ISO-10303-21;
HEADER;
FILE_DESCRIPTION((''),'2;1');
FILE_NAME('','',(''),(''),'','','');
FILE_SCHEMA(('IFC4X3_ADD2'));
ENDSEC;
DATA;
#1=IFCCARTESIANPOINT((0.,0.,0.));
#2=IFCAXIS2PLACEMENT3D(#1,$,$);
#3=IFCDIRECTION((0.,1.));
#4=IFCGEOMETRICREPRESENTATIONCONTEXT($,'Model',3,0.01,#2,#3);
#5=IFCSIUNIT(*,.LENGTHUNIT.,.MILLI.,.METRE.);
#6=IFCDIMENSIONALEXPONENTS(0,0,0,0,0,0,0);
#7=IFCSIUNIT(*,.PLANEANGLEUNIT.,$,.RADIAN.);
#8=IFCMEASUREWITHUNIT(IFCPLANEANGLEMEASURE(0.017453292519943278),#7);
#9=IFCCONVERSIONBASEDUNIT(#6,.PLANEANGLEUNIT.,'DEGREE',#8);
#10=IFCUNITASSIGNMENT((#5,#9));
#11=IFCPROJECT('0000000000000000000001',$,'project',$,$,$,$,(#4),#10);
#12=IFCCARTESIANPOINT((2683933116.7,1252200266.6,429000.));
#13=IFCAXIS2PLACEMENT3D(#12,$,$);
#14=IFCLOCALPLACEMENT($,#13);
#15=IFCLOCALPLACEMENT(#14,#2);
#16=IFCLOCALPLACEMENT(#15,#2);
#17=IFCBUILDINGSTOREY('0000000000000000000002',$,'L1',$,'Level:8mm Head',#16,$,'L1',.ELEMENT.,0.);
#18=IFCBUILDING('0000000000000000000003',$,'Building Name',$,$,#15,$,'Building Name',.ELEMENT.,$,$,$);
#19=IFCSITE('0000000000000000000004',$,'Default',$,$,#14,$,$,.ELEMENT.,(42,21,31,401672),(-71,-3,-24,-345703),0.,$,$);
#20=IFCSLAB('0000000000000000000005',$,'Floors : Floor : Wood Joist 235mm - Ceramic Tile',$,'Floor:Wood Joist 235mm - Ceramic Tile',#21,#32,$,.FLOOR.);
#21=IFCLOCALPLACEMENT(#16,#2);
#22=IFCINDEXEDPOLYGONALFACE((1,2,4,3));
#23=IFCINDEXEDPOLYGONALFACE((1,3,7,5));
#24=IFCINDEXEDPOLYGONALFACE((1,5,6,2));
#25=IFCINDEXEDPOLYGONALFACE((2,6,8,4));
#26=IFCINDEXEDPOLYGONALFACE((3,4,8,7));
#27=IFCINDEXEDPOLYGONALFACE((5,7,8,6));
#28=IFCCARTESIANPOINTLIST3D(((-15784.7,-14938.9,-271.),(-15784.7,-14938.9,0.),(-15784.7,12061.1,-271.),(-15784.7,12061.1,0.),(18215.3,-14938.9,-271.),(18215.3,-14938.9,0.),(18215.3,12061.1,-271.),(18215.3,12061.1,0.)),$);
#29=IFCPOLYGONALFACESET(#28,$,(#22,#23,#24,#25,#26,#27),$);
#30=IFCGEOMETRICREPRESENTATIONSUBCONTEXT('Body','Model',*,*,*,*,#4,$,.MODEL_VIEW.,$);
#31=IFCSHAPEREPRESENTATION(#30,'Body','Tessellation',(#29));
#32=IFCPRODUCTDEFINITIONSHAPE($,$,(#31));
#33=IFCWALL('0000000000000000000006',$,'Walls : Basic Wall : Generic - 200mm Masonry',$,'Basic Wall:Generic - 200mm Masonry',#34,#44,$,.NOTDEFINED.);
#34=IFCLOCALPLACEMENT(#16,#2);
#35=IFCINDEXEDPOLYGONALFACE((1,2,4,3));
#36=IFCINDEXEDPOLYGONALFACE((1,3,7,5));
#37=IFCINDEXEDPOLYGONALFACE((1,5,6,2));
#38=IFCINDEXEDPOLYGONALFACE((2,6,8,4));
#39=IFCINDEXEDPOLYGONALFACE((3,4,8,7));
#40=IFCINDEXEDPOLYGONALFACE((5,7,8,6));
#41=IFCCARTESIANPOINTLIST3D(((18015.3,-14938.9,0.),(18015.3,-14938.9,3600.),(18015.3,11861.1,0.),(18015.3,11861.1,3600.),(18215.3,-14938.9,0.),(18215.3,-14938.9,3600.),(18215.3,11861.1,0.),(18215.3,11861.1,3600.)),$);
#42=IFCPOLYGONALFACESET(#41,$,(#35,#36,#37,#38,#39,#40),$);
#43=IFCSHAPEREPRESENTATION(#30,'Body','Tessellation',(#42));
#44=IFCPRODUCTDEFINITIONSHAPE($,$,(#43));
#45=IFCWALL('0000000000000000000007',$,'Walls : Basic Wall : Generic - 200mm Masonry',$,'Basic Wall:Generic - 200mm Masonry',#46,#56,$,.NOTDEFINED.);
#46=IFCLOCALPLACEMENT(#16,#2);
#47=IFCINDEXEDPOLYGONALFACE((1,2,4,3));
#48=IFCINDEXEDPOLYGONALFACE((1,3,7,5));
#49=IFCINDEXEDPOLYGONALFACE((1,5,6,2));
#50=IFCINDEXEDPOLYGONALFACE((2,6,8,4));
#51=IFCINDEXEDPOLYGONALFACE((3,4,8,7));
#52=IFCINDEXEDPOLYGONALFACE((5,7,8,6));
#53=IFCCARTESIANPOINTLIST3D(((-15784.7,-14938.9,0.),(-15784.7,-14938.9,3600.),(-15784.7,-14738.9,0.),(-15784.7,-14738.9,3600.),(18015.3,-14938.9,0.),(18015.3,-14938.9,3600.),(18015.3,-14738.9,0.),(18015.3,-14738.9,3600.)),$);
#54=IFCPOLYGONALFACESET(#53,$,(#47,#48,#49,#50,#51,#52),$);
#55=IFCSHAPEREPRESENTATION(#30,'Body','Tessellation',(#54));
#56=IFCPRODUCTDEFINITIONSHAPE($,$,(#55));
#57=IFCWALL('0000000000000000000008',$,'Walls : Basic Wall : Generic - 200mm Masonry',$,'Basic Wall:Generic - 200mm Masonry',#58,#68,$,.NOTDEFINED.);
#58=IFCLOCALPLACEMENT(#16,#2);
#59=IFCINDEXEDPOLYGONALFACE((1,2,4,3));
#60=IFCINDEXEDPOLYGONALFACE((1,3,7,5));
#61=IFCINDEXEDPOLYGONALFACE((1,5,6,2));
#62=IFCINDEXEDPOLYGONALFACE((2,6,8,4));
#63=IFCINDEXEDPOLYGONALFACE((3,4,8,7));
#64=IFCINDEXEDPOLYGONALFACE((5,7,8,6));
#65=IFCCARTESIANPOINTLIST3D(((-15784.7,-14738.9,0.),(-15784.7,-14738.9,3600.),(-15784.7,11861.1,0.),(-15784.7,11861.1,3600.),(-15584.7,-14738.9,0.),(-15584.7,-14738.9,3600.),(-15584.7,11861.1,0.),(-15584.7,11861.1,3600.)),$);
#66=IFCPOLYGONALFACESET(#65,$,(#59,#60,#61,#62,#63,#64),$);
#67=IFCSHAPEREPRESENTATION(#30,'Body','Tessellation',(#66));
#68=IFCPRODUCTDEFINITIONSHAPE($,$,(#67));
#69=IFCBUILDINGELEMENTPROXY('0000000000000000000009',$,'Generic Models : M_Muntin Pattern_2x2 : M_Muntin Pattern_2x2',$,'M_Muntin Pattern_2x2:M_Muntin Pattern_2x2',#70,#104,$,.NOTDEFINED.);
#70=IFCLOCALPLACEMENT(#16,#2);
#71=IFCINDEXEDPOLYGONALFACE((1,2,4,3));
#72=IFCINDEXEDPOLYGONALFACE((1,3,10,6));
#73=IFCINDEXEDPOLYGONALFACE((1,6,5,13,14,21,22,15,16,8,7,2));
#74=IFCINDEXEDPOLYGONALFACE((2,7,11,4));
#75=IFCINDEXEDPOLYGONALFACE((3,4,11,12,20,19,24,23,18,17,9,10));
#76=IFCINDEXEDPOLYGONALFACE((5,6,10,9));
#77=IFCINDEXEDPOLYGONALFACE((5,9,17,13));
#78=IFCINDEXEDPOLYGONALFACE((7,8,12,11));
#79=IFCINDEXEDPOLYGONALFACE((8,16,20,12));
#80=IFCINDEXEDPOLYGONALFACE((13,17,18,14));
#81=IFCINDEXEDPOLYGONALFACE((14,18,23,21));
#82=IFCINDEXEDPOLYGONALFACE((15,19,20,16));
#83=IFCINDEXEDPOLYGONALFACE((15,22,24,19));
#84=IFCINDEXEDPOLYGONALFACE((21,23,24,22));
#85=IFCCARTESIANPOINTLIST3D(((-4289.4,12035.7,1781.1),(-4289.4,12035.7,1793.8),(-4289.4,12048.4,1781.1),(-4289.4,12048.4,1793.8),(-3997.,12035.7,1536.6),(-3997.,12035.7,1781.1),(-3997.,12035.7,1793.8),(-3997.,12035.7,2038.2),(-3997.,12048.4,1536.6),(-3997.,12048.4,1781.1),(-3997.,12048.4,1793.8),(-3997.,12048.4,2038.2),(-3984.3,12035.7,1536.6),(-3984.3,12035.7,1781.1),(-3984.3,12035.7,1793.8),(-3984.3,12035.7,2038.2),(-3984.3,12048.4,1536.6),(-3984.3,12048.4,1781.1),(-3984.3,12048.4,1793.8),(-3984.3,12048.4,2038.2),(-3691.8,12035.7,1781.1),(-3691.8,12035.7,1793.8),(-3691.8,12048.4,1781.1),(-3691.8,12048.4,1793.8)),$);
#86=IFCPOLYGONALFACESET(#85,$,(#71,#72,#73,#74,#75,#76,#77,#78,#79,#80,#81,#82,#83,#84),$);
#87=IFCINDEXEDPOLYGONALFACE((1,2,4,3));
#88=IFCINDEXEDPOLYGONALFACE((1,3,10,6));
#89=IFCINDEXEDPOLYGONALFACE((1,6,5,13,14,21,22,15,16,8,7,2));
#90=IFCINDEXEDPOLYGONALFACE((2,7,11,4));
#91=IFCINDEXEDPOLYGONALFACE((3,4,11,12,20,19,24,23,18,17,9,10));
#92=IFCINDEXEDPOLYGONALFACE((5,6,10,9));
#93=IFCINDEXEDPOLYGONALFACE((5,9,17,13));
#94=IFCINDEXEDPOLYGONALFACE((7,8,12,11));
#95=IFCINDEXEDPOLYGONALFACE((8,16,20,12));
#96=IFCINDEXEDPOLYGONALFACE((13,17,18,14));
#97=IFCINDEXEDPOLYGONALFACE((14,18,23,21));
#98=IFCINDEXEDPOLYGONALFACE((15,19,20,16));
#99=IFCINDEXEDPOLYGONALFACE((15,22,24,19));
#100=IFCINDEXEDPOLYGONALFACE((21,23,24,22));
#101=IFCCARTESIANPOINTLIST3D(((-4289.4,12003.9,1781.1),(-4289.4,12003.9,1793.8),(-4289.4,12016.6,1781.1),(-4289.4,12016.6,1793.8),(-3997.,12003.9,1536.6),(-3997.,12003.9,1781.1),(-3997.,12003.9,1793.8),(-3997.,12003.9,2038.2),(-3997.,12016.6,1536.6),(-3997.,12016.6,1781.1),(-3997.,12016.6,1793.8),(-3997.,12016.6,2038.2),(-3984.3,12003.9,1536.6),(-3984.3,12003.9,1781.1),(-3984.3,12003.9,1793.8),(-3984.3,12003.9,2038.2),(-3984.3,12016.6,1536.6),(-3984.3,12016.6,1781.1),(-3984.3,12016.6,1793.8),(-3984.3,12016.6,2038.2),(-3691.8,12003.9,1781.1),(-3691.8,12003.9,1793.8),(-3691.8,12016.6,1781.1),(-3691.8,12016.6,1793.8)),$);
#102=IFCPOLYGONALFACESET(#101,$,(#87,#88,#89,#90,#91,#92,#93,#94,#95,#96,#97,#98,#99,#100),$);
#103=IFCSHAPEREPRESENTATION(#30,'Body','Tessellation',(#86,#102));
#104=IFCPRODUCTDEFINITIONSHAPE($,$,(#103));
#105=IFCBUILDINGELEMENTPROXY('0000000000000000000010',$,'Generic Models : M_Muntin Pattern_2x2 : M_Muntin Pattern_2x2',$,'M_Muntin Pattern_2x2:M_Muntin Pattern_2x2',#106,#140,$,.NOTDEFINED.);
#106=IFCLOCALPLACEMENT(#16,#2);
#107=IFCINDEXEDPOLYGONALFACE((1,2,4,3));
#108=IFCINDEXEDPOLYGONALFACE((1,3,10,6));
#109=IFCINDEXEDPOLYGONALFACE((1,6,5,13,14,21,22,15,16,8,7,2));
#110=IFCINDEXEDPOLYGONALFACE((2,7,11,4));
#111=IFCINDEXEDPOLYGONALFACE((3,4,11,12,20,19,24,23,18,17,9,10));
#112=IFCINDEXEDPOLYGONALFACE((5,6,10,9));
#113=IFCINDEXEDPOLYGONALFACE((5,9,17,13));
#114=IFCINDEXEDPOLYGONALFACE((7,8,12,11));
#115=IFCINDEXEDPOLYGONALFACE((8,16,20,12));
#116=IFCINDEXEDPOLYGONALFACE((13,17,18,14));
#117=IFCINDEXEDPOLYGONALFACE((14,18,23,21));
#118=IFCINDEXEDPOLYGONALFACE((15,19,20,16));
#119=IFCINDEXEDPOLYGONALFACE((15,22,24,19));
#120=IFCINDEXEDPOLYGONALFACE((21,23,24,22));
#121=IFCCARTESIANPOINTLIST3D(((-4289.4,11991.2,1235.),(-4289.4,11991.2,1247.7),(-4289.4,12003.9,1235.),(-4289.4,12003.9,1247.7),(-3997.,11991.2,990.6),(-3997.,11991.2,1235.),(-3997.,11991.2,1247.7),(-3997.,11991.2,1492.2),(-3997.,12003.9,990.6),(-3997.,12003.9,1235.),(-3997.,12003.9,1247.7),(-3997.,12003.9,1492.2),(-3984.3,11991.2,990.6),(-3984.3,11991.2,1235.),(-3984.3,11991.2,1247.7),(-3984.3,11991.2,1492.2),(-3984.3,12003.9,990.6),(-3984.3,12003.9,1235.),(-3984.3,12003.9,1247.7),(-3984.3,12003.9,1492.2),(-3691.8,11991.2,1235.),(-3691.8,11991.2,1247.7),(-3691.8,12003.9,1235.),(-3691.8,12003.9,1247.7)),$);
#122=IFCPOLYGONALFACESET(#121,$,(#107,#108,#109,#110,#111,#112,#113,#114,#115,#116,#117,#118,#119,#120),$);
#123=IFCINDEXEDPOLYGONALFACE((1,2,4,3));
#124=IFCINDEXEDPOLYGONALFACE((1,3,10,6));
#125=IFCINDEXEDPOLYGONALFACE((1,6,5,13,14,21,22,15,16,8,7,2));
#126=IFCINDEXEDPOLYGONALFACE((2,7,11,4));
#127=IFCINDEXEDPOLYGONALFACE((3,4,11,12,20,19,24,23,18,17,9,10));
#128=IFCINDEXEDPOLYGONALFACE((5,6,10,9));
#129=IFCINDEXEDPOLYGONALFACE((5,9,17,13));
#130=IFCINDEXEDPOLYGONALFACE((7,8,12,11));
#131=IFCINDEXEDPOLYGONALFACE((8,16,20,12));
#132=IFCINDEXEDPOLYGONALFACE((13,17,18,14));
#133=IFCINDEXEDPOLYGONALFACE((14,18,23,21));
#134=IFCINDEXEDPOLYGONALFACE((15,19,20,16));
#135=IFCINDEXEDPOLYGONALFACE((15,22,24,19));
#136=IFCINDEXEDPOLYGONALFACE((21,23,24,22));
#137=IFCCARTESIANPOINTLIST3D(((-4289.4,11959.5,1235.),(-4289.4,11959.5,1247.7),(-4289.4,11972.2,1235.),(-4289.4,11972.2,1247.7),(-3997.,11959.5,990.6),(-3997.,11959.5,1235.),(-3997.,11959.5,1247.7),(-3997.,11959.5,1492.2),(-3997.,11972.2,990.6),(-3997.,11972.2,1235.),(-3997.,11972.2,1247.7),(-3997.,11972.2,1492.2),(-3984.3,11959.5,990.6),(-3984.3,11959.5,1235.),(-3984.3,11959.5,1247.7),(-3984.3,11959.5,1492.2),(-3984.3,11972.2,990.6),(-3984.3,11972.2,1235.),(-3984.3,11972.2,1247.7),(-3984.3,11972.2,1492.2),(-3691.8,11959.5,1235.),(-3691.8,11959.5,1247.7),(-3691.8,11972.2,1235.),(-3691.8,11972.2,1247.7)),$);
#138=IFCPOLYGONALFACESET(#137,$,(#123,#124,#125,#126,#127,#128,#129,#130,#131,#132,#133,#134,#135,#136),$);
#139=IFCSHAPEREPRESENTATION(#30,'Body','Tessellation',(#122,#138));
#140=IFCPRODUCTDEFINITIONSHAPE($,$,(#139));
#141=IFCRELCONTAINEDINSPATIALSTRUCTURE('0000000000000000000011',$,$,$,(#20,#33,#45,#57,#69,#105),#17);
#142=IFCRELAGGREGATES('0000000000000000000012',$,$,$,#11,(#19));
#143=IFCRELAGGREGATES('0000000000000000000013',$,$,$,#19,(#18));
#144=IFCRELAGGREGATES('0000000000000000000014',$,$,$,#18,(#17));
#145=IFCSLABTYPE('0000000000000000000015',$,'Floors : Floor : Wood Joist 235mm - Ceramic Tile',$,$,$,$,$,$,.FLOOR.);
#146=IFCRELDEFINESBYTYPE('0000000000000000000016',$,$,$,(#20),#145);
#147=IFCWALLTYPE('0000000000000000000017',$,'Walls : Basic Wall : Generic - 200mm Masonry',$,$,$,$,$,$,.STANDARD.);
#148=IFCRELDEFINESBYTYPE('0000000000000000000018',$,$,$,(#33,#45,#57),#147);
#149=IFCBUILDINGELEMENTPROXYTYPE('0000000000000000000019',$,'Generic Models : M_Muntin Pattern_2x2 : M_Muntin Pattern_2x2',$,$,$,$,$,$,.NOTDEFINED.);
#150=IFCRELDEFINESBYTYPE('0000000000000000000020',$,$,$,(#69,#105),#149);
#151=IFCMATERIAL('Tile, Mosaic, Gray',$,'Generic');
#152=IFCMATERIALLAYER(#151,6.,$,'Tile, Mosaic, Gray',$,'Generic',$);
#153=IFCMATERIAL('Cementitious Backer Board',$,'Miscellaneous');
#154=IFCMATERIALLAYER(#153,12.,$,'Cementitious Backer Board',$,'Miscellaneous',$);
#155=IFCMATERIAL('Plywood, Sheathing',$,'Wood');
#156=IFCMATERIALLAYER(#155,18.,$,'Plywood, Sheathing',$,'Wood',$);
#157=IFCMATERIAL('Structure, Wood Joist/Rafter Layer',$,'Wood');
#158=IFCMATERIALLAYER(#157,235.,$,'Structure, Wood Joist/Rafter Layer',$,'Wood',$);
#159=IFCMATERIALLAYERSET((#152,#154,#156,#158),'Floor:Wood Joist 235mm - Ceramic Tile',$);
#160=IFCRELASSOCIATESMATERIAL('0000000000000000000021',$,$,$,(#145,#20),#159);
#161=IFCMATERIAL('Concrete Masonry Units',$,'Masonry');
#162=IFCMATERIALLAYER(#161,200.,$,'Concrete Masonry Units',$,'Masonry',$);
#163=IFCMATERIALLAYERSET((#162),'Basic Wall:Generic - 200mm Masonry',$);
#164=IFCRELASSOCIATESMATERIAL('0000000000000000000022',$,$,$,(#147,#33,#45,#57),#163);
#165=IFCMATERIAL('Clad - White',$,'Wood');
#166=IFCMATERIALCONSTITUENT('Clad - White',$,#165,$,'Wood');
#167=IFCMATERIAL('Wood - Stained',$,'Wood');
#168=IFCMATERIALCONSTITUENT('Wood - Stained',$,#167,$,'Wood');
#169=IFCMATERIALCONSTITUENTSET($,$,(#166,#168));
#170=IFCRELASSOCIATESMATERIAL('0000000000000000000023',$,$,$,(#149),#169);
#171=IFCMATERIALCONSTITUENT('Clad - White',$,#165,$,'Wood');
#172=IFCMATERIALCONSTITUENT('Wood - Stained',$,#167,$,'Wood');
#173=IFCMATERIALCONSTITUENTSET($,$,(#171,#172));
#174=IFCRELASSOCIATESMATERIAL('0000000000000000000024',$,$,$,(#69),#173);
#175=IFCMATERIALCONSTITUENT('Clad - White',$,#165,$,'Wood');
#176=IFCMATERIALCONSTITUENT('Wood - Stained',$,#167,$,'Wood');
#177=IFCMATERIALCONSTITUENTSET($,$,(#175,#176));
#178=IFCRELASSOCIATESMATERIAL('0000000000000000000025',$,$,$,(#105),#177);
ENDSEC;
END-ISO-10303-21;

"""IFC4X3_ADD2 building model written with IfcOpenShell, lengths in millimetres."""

from ifc_helpers import new_model, entity, si_unit, converted_unit, direction, frame, frame_2d, origin, origin_2d_with_axis, place, context, subcontext, project, spatial, polyline, rectangle, outline, extrude, source, transform, mapped, material, layer, layer_set, layer_usage, constituent, constituent_set, type_object, type_shapes, element, save


model = new_model("IFC4X3_ADD2")

# Units and contexts
model_context = context("Model", 3, precision=0.01, world=origin(), true_north=direction((0.0, 1.0)))
body_context = subcontext(model_context, "Body", "Model", "MODEL_VIEW")
ifc_project = project(units=[si_unit("LENGTHUNIT", "METRE", prefix="MILLI"), converted_unit("PLANEANGLEUNIT", "DEGREE", entity("IfcPlaneAngleMeasure", 0.017453292519943278), si_unit("PLANEANGLEUNIT", "RADIAN"), dimensions=[0, 0, 0, 0, 0, 0, 0])], contexts=[model_context])

# Site, building, storey
site_placement = place(None, frame((2683933116.7, 1252200266.6, 429000.0)))
site = spatial("IfcSite", under=ifc_project, at=site_placement, Name="Default", CompositionType="ELEMENT", RefLatitude=(42, 21, 31, 401672), RefLongitude=(-71, -3, -24, -345703), RefElevation=0.0)
building_placement = place(site_placement, origin())
building = spatial("IfcBuilding", under=site, at=building_placement, Name="Building Name", LongName="Building Name", CompositionType="ELEMENT")
storey_placement = place(building_placement, origin())
storey = spatial("IfcBuildingStorey", under=building, at=storey_placement, Name="L1", ObjectType="Level:8mm Head", LongName="L1", CompositionType="ELEMENT", Elevation=0.0)

# Slab
ifc_material_1 = material(Name="Tile, Mosaic, Gray", Category="Generic")
ifc_layer_1 = layer(ifc_material_1, 6.0, Name="Tile, Mosaic, Gray", Category="Generic")
ifc_material_2 = material(Name="Cementitious Backer Board", Category="Miscellaneous")
ifc_layer_2 = layer(ifc_material_2, 12.0, Name="Cementitious Backer Board", Category="Miscellaneous")
ifc_material_3 = material(Name="Plywood, Sheathing", Category="Wood")
ifc_layer_3 = layer(ifc_material_3, 18.0, Name="Plywood, Sheathing", Category="Wood")
ifc_material_4 = material(Name="Structure, Wood Joist/Rafter Layer", Category="Wood")
ifc_layer_4 = layer(ifc_material_4, 235.0, Name="Structure, Wood Joist/Rafter Layer", Category="Wood")
ifc_layer_set_1 = layer_set([ifc_layer_1, ifc_layer_2, ifc_layer_3, ifc_layer_4], Name="Floor:Wood Joist 235mm - Ceramic Tile")
ifc_layer_usage = layer_usage(ifc_layer_set_1, "AXIS3", "POSITIVE", 0.0)
slab_type = type_object("IfcSlabType", Name="Floors : Floor : Wood Joist 235mm - Ceramic Tile", PredefinedType="FLOOR", material=ifc_layer_set_1)
slab_placement = place(storey_placement, origin())
element("IfcSlab", 1, at=slab_placement, inside=storey, type_object=slab_type, material=ifc_layer_usage, Name="Floors : Floor : Wood Joist 235mm - Ceramic Tile", ObjectType="Floor:Wood Joist 235mm - Ceramic Tile", PredefinedType="FLOOR", context=body_context, shape_type="SweptSolid", body=[
    extrude(rectangle(XDim=27000.0, YDim=34000.0, at=origin_2d_with_axis()), frame((1215.3, -1438.9, 0.0), z_axis=(0.0, 0.0, -1.0), x_axis=(0.0, 1.0, 0.0)), (0.0, 0.0, 1.0), 271.0),
])

# Shared definitions
ifc_material_5 = material(Name="Concrete Masonry Units", Category="Masonry")
ifc_layer_5 = layer(ifc_material_5, 200.0, Name="Concrete Masonry Units", Category="Masonry")
ifc_layer_set_2 = layer_set([ifc_layer_5], Name="Basic Wall:Generic - 200mm Masonry")
wall_type = type_object("IfcWallType", Name="Walls : Basic Wall : Generic - 200mm Masonry", PredefinedType="STANDARD", material=ifc_layer_set_2)
ifc_material_6 = material(Name="Wood - Stained", Category="Wood")

# Walls
wall_1_placement = place(storey_placement, frame((18115.3, 11861.1, 0.0), z_axis=(0.0, 0.0, 1.0), x_axis=(0.0, -1.0, 0.0)))
element("IfcWall", 2, at=wall_1_placement, inside=storey, type_object=wall_type, material=ifc_layer_set_2, Name="Walls : Basic Wall : Generic - 200mm Masonry", ObjectType="Basic Wall:Generic - 200mm Masonry", PredefinedType="NOTDEFINED", context=body_context, shape_type="SweptSolid", body=[
    extrude(rectangle(XDim=26800.0, YDim=200.0, at=frame_2d((13400.0, 0.0), x_axis=(-1.0, 0.0))), origin(), (0.0, 0.0, 1.0), 3600.0),
])
wall_2_placement = place(storey_placement, frame((18015.3, -14838.9, 0.0), z_axis=(0.0, 0.0, 1.0), x_axis=(-1.0, 0.0, 0.0)))
element("IfcWall", 3, at=wall_2_placement, inside=storey, type_object=wall_type, material=ifc_layer_set_2, Name="Walls : Basic Wall : Generic - 200mm Masonry", ObjectType="Basic Wall:Generic - 200mm Masonry", PredefinedType="NOTDEFINED", context=body_context, shape_type="SweptSolid", body=[
    extrude(rectangle(XDim=33800.0, YDim=200.0, at=frame_2d((16900.0, 0.0), x_axis=(-1.0, 0.0))), origin(), (0.0, 0.0, 1.0), 3600.0),
])
wall_3_placement = place(storey_placement, frame((-15684.7, -14738.9, 0.0), z_axis=(0.0, 0.0, 1.0), x_axis=(0.0, 1.0, 0.0)))
element("IfcWall", 4, at=wall_3_placement, inside=storey, type_object=wall_type, material=ifc_layer_set_2, Name="Walls : Basic Wall : Generic - 200mm Masonry", ObjectType="Basic Wall:Generic - 200mm Masonry", PredefinedType="NOTDEFINED", context=body_context, shape_type="SweptSolid", body=[
    extrude(rectangle(XDim=26600.0, YDim=200.0, at=frame_2d((13300.0, 0.0), x_axis=(-1.0, 0.0))), origin(), (0.0, 0.0, 1.0), 3600.0),
])

# Building element proxies
ifc_material_7 = material(Name="Clad - White", Category="Wood")
ifc_constituent_1 = constituent(ifc_material_7, Name="Clad - White", Category="Wood")
ifc_constituent_2 = constituent(ifc_material_6, Name="Wood - Stained", Category="Wood")
ifc_constituent_set_1 = constituent_set(constituents=[ifc_constituent_1, ifc_constituent_2])
ifc_constituent_3 = constituent(ifc_material_7, Name="Clad - White", Category="Wood")
ifc_constituent_4 = constituent(ifc_material_6, Name="Wood - Stained", Category="Wood")
ifc_constituent_set_2 = constituent_set(constituents=[ifc_constituent_3, ifc_constituent_4])
building_element_proxy_type_1 = type_object("IfcBuildingElementProxyType", Name="Generic Models : M_Muntin Pattern_2x2 : M_Muntin Pattern_2x2", PredefinedType="NOTDEFINED", material=ifc_constituent_set_2)
shared_shape_1 = source(origin(), body_context, "Body", "SweptSolid", [
    extrude(outline(polyline([(6.4, -6.4), (250.8, -6.4), (250.8, 6.3), (6.4, 6.3), (6.4, 298.8), (-6.3, 298.8), (-6.3, 6.3), (-250.8, 6.3), (-250.8, -6.4), (-6.3, -6.4), (-6.3, -298.8), (6.4, -298.8), (6.4, -6.4)])), frame((0.0, 9.5, 250.8), z_axis=(0.0, 1.0, 0.0), x_axis=(0.0, 0.0, 1.0)), (0.0, 0.0, 1.0), 12.7),
    extrude(outline(polyline([(6.4, -6.4), (250.8, -6.4), (250.8, 6.3), (6.4, 6.3), (6.4, 298.8), (-6.3, 298.8), (-6.3, 6.3), (-250.8, 6.3), (-250.8, -6.4), (-6.3, -6.4), (-6.3, -298.8), (6.4, -298.8), (6.4, -6.4)])), frame((0.0, -22.2, 250.8), z_axis=(0.0, 1.0, 0.0), x_axis=(0.0, 0.0, 1.0)), (0.0, 0.0, 1.0), 12.7),
])
type_shapes(building_element_proxy_type_1, [shared_shape_1])
proxy_1_placement = place(storey_placement, frame((-3990.6, 12026.1, 1536.6)))
element("IfcBuildingElementProxy", 5, at=proxy_1_placement, inside=storey, type_object=building_element_proxy_type_1, material=ifc_constituent_set_1, Name="Generic Models : M_Muntin Pattern_2x2 : M_Muntin Pattern_2x2", ObjectType="M_Muntin Pattern_2x2:M_Muntin Pattern_2x2", PredefinedType="NOTDEFINED", context=body_context, shape_type="MappedRepresentation", body=[
    mapped(shared_shape_1, transform((0.0, 0.0, 0.0), scale=1.0)),
])
ifc_constituent_5 = constituent(ifc_material_7, Name="Clad - White", Category="Wood")
ifc_constituent_6 = constituent(ifc_material_6, Name="Wood - Stained", Category="Wood")
ifc_constituent_set_3 = constituent_set(constituents=[ifc_constituent_5, ifc_constituent_6])
proxy_2_placement = place(storey_placement, frame((-3990.6, 11981.7, 990.6)))
element("IfcBuildingElementProxy", 6, at=proxy_2_placement, inside=storey, type_object=building_element_proxy_type_1, material=ifc_constituent_set_3, Name="Generic Models : M_Muntin Pattern_2x2 : M_Muntin Pattern_2x2", ObjectType="M_Muntin Pattern_2x2:M_Muntin Pattern_2x2", PredefinedType="NOTDEFINED", context=body_context, shape_type="MappedRepresentation", body=[
    mapped(shared_shape_1, transform((0.0, 0.0, 0.0), scale=1.0)),
])

save(model, "model.ifc")
